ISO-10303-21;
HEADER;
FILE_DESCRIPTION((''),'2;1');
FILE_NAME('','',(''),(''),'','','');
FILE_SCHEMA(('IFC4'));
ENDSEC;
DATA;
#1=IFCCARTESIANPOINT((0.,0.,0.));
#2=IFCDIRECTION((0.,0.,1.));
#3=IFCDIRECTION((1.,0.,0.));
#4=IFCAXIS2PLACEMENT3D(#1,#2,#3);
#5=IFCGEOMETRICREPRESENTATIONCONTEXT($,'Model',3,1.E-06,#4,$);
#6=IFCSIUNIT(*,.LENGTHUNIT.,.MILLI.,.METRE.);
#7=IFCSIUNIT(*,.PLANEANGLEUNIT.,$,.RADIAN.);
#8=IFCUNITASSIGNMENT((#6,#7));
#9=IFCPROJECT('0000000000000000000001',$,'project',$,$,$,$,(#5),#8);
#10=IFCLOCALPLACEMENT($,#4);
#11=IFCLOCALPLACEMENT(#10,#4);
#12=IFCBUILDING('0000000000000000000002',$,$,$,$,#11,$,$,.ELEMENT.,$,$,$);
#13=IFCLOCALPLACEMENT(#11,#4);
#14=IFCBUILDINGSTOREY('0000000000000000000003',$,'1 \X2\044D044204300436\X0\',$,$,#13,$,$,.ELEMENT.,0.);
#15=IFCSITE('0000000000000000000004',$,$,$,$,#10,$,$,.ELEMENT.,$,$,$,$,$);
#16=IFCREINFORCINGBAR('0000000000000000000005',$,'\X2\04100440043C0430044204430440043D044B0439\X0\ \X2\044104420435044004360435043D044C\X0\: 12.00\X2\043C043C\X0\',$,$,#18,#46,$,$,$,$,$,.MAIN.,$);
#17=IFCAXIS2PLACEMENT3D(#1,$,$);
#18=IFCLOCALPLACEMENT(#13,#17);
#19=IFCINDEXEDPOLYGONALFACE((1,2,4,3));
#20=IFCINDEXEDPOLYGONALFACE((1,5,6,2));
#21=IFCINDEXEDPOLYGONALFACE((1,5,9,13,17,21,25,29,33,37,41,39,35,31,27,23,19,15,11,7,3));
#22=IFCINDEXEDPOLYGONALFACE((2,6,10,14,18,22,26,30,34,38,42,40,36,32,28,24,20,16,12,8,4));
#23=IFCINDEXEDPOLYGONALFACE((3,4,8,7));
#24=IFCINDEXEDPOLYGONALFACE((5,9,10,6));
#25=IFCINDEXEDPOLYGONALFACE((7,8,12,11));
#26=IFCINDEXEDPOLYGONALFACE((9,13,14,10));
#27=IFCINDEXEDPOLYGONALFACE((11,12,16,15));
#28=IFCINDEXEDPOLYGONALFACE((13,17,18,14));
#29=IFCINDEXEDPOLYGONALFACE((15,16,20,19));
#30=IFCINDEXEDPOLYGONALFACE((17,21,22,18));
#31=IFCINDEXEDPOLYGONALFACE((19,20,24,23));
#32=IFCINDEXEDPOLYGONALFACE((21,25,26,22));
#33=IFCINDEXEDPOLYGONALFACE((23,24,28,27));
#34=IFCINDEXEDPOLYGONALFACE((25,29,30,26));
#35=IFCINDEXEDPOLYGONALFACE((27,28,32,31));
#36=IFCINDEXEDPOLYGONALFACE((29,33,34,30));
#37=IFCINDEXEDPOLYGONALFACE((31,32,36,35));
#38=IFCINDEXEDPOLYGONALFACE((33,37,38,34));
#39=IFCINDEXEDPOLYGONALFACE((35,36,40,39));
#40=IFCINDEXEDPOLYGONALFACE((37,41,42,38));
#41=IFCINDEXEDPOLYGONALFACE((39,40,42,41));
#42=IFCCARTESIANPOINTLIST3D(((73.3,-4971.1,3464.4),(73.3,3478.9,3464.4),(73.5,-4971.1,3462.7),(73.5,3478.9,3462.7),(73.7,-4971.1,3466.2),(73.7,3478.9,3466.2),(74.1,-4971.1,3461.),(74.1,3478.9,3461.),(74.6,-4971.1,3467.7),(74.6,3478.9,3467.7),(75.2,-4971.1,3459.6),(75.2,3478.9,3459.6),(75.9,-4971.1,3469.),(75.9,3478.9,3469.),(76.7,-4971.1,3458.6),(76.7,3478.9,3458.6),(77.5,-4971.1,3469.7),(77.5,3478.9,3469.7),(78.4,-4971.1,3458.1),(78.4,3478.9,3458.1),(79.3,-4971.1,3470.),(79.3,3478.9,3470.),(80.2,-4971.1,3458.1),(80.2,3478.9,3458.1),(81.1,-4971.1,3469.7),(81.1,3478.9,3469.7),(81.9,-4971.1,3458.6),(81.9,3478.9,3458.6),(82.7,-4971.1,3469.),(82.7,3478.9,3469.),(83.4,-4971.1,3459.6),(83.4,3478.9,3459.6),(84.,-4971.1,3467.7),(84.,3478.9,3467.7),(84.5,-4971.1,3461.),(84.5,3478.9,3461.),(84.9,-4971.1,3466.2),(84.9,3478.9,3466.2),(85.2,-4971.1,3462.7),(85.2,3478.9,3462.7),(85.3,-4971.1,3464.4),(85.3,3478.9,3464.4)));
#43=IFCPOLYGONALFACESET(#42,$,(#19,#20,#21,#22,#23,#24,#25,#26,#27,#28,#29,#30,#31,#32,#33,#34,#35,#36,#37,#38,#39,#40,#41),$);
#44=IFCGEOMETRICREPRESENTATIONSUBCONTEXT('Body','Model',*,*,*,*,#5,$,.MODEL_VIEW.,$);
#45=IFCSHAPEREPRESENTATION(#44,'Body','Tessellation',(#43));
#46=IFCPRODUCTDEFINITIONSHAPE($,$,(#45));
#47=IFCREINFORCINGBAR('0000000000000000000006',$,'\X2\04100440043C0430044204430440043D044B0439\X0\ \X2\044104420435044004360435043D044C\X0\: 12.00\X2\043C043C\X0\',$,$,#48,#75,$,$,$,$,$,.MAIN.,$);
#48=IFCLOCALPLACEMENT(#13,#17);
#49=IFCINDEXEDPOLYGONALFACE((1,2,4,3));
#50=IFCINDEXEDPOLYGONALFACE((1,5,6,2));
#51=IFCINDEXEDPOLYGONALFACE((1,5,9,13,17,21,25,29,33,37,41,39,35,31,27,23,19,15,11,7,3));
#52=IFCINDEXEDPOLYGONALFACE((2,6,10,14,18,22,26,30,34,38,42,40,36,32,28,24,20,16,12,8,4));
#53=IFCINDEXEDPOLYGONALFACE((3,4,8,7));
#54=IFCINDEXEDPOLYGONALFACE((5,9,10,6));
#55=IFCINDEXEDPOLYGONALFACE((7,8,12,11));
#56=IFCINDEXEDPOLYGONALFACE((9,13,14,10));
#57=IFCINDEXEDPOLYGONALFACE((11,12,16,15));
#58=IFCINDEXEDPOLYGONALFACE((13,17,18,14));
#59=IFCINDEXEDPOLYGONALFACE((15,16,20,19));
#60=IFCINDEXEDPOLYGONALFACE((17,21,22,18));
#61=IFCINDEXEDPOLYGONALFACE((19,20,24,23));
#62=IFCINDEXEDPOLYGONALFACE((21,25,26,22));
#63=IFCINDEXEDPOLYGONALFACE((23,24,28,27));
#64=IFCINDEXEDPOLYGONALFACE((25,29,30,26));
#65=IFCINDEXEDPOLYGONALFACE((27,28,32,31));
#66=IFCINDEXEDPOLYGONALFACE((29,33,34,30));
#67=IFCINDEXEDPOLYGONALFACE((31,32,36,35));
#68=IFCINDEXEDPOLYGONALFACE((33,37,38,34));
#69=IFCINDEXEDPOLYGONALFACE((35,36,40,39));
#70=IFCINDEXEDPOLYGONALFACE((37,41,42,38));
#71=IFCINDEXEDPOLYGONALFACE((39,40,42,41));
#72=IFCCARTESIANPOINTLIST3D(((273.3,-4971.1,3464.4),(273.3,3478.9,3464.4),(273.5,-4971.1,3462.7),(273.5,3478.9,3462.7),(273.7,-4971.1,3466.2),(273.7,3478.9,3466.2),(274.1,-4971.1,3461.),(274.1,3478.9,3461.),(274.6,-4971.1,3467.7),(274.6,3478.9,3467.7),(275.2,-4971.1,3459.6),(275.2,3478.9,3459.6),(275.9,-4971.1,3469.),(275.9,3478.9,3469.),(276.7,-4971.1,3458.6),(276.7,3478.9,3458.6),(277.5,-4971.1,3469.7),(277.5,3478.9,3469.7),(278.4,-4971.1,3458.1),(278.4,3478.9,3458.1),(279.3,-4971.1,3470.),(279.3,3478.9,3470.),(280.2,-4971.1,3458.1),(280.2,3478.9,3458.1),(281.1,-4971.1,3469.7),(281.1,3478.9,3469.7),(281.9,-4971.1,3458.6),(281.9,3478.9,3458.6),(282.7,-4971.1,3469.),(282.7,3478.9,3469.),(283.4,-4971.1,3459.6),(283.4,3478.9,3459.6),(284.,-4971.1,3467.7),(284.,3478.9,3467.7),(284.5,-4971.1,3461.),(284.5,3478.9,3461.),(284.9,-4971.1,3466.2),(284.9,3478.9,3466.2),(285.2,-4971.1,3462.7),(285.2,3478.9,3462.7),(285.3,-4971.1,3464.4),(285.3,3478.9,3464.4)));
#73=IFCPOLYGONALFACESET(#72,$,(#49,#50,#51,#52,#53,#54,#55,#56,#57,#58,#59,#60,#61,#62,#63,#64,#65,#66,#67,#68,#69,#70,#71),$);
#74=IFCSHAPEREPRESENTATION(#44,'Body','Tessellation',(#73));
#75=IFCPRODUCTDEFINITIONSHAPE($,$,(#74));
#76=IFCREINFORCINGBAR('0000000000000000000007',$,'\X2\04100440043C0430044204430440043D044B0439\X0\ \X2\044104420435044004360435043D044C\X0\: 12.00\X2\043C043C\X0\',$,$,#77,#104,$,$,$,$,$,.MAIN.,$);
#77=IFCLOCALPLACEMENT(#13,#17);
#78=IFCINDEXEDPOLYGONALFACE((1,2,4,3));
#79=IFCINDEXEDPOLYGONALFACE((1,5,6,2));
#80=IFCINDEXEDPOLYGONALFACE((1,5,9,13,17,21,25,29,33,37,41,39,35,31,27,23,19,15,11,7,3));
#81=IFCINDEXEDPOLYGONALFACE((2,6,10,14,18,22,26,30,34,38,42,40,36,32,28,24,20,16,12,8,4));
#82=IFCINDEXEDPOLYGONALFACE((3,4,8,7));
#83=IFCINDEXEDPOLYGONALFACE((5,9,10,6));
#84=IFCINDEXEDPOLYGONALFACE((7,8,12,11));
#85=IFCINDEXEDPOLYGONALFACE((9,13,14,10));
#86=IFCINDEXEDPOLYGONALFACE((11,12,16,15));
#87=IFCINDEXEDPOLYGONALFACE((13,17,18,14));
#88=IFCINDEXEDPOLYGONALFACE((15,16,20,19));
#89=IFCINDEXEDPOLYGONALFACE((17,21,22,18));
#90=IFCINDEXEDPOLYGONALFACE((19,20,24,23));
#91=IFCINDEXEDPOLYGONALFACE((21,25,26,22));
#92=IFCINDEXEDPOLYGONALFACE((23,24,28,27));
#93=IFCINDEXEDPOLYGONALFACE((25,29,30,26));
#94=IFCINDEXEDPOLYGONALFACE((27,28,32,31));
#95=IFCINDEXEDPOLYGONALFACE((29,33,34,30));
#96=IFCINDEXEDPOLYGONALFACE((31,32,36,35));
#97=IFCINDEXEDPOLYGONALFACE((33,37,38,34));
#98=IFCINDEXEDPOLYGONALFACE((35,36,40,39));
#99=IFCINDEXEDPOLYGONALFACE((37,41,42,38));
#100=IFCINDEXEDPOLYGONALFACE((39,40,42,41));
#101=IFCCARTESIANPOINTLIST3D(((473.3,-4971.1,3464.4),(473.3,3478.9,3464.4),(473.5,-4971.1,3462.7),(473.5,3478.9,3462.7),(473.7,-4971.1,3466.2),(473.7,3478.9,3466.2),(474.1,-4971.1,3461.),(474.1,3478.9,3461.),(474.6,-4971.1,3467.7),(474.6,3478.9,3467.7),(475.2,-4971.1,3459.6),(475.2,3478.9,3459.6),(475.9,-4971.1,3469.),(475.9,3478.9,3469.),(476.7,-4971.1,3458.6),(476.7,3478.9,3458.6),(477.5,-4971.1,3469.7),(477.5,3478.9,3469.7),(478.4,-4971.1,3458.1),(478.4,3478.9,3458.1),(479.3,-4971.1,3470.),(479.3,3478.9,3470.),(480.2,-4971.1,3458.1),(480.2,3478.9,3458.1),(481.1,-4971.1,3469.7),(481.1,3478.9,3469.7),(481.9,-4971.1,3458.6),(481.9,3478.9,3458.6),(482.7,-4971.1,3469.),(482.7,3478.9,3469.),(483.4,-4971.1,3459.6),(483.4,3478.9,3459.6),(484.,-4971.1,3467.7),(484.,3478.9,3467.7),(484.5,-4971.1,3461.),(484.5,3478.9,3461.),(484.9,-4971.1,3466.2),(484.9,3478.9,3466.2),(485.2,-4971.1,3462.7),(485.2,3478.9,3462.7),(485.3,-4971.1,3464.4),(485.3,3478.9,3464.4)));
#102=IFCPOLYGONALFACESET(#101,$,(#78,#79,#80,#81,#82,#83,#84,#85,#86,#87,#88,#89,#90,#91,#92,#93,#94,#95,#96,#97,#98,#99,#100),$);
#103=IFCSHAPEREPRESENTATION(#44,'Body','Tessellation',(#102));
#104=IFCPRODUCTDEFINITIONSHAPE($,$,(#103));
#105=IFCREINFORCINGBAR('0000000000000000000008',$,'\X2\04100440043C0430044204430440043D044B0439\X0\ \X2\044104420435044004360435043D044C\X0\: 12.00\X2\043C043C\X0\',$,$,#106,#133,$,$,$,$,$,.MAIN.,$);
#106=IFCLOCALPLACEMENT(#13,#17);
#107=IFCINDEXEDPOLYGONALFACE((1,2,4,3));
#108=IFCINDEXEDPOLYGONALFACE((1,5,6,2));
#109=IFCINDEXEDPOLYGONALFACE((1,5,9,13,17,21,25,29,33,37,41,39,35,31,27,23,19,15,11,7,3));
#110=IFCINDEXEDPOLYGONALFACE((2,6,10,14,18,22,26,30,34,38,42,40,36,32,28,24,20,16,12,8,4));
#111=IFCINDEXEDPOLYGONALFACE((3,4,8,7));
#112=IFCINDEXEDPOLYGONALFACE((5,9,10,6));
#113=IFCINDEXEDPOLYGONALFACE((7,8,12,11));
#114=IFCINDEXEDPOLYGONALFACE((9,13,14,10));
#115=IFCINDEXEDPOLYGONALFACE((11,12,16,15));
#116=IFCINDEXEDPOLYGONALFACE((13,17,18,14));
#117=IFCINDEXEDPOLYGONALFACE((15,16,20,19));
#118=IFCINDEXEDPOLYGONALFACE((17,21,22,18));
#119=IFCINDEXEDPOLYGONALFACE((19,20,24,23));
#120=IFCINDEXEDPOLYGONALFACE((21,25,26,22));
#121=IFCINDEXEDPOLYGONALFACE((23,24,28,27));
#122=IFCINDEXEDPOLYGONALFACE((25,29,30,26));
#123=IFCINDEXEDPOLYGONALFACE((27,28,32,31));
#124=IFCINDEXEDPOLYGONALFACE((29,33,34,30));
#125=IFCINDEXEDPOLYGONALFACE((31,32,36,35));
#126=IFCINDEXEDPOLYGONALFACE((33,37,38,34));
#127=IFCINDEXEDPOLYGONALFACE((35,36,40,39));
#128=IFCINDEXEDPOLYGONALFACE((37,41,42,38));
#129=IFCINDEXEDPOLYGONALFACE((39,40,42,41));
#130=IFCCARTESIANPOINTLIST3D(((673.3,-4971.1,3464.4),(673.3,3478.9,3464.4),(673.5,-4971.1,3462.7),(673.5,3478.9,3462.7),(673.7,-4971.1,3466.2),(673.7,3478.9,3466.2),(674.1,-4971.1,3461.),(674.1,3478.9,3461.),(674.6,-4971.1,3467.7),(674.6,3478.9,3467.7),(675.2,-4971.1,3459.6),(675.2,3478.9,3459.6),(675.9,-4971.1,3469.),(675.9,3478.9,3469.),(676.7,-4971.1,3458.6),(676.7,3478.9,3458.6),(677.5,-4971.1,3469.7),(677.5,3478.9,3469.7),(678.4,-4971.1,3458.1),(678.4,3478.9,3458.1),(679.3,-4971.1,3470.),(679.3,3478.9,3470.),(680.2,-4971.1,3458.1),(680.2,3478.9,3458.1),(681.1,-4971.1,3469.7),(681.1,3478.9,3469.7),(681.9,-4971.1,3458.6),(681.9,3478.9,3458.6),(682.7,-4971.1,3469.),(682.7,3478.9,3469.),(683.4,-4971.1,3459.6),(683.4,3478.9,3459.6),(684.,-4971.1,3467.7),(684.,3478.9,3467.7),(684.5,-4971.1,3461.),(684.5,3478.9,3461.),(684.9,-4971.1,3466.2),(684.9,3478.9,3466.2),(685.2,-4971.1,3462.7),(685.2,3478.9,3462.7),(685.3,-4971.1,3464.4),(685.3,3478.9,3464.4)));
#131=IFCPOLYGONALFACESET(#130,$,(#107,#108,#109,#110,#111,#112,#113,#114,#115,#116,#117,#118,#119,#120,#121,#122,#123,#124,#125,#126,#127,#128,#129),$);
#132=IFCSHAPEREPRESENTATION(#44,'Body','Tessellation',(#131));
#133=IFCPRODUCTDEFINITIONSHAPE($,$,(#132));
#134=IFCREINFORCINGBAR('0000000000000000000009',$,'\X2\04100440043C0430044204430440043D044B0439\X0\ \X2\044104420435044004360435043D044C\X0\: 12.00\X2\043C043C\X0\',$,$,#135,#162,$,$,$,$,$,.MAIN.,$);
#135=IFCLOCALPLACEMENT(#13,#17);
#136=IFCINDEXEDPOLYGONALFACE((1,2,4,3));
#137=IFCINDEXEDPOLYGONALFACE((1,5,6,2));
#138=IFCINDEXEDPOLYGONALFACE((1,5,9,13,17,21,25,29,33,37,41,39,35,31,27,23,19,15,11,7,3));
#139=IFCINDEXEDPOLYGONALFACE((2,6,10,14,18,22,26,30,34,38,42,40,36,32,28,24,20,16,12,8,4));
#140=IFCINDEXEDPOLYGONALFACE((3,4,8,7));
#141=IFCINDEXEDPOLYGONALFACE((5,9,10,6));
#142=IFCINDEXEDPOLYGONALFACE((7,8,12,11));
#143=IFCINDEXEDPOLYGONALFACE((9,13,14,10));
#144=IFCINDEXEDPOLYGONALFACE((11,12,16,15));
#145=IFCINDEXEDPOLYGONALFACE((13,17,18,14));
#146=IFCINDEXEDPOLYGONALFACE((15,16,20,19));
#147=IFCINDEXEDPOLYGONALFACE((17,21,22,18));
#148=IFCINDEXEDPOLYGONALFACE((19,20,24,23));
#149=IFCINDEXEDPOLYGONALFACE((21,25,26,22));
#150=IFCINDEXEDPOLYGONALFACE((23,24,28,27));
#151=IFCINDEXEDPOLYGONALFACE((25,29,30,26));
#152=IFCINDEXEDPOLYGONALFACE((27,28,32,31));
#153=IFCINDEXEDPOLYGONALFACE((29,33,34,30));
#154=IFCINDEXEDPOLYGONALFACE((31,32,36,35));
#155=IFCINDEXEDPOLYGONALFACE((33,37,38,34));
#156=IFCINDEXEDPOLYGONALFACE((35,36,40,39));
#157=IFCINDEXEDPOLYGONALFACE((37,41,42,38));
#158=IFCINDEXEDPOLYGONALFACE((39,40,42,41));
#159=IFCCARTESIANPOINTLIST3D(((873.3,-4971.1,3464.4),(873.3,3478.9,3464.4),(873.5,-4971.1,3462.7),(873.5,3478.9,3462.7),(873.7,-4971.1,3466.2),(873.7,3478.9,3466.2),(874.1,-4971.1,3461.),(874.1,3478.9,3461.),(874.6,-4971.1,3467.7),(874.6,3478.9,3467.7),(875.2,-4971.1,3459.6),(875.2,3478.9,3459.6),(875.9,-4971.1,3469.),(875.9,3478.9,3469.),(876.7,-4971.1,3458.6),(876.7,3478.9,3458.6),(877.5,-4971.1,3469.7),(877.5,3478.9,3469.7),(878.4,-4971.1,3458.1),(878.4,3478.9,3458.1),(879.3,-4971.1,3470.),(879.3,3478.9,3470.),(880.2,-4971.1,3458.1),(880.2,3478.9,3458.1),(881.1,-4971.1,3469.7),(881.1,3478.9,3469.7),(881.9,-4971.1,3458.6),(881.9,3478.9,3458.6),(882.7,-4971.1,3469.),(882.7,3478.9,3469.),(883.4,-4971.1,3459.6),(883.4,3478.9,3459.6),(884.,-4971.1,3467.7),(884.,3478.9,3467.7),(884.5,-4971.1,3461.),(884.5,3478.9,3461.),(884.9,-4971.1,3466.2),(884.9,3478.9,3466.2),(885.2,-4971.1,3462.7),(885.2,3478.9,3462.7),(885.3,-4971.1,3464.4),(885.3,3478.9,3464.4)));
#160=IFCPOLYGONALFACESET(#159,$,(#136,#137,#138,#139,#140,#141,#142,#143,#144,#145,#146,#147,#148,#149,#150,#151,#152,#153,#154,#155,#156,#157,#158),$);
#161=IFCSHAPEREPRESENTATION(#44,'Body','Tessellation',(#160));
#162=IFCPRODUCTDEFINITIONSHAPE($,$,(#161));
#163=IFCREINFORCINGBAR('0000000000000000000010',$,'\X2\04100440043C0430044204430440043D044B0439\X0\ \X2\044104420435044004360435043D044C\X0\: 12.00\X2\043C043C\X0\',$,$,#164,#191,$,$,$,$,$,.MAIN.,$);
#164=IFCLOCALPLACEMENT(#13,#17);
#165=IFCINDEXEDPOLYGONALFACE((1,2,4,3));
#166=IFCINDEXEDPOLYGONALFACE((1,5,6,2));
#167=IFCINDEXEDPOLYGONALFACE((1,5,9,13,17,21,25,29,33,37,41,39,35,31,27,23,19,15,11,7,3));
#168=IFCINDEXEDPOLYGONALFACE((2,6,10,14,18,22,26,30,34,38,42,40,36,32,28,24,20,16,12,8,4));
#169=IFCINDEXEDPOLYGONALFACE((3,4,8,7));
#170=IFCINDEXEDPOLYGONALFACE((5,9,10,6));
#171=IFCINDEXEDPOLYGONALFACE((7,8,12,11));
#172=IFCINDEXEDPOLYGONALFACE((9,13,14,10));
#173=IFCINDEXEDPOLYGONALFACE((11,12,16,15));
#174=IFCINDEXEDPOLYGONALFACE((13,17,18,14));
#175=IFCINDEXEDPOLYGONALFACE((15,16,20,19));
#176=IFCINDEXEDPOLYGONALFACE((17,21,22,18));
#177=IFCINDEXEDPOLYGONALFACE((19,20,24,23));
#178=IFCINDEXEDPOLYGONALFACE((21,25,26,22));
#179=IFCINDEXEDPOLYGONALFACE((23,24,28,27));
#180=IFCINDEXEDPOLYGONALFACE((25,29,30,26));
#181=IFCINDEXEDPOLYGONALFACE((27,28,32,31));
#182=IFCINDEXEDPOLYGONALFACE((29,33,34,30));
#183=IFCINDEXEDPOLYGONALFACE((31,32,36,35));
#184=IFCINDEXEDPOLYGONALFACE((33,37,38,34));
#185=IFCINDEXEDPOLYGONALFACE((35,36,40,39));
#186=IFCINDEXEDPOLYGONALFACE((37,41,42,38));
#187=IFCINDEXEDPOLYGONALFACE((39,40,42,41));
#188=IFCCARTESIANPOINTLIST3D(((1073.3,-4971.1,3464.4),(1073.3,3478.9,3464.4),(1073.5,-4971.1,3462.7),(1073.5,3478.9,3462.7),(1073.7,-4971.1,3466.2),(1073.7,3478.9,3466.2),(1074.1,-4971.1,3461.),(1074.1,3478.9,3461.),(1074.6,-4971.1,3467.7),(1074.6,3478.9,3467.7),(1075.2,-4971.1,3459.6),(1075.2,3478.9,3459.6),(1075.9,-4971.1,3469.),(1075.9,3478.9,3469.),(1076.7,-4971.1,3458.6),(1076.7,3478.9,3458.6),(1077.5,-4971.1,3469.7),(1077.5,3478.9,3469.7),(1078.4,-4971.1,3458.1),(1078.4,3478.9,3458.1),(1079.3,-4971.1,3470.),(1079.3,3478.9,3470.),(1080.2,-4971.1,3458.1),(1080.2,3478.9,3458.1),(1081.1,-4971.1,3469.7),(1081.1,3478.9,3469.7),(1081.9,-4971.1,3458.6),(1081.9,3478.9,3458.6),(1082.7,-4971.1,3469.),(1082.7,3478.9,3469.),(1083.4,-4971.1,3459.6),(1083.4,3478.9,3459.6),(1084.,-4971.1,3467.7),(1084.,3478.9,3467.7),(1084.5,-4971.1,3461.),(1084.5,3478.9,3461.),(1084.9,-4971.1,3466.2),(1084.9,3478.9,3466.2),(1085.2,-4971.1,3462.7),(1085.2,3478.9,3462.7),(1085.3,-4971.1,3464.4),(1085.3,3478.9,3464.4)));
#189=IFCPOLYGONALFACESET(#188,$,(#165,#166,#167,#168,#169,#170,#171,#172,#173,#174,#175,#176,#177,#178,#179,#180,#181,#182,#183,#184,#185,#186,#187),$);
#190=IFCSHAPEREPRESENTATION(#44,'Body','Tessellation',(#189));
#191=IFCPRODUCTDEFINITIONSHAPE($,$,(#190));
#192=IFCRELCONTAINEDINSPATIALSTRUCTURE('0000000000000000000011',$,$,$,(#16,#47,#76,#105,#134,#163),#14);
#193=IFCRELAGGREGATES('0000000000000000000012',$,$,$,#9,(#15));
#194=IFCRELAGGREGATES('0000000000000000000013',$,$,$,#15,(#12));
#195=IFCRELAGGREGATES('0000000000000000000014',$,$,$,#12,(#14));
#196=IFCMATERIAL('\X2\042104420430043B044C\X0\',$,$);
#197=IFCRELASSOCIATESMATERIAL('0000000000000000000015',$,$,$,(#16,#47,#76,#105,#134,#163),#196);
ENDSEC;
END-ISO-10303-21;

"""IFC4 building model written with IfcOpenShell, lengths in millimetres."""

from ifc_helpers import new_model, entity, si_unit, origin_with_axes, place, context, subcontext, project, spatial, source, transform, mapped, material, element, save


model = new_model("IFC4")

# Units and contexts
model_context = context("Model", 3, precision=1e-06, world=origin_with_axes())
body_context = subcontext(model_context, "Body", "Model", "MODEL_VIEW")
ifc_project = project(units=[si_unit("LENGTHUNIT", "METRE", prefix="MILLI"), si_unit("PLANEANGLEUNIT", "RADIAN")], contexts=[model_context])

# Site, building, storey
site_placement = place(None, origin_with_axes())
site = spatial("IfcSite", under=ifc_project, at=site_placement, CompositionType="ELEMENT")
building_placement = place(site_placement, origin_with_axes())
building = spatial("IfcBuilding", under=site, at=building_placement, CompositionType="ELEMENT")
storey_placement = place(building_placement, origin_with_axes())
storey = spatial("IfcBuildingStorey", under=building, at=storey_placement, Name="1 этаж", CompositionType="ELEMENT", Elevation=0.0)

# Reinforcing bars
ifc_material = material(Name="Сталь")
shared_shape = source(origin_with_axes(), body_context, "Body", "AdvancedSweptSolid", [
    entity("IfcSweptDiskSolid", entity("IfcIndexedPolyCurve", entity("IfcCartesianPointList3D", [[0.0, 0.0, 0.0], [8450.0, 0.0, 0.0]]), [entity("IfcLineIndex", [1, 2])]), 6.0),
])
reinforcing_bar_1_placement = place(storey_placement, origin_with_axes())
element("IfcReinforcingBar", 1, at=reinforcing_bar_1_placement, inside=storey, material=ifc_material, Name="Арматурный стержень: 12.00мм", PredefinedType="MAIN", context=body_context, shape_type="MappedRepresentation", body=[
    mapped(shared_shape, transform((79.3, -4971.1, 3464.0), x_axis=(0.0, 1.0, 0.0), y_axis=(-1.0, 0.0, 0.0), z_axis=(0.0, 0.0, 1.0), scale=1.0)),
])
reinforcing_bar_2_placement = place(storey_placement, origin_with_axes())
element("IfcReinforcingBar", 2, at=reinforcing_bar_2_placement, inside=storey, material=ifc_material, Name="Арматурный стержень: 12.00мм", PredefinedType="MAIN", context=body_context, shape_type="MappedRepresentation", body=[
    mapped(shared_shape, transform((279.3, -4971.1, 3464.0), x_axis=(0.0, 1.0, 0.0), y_axis=(-1.0, 0.0, 0.0), z_axis=(0.0, 0.0, 1.0), scale=1.0)),
])
reinforcing_bar_3_placement = place(storey_placement, origin_with_axes())
element("IfcReinforcingBar", 3, at=reinforcing_bar_3_placement, inside=storey, material=ifc_material, Name="Арматурный стержень: 12.00мм", PredefinedType="MAIN", context=body_context, shape_type="MappedRepresentation", body=[
    mapped(shared_shape, transform((479.3, -4971.1, 3464.0), x_axis=(0.0, 1.0, 0.0), y_axis=(-1.0, 0.0, 0.0), z_axis=(0.0, 0.0, 1.0), scale=1.0)),
])
reinforcing_bar_4_placement = place(storey_placement, origin_with_axes())
element("IfcReinforcingBar", 4, at=reinforcing_bar_4_placement, inside=storey, material=ifc_material, Name="Арматурный стержень: 12.00мм", PredefinedType="MAIN", context=body_context, shape_type="MappedRepresentation", body=[
    mapped(shared_shape, transform((679.3, -4971.1, 3464.0), x_axis=(0.0, 1.0, 0.0), y_axis=(-1.0, 0.0, 0.0), z_axis=(0.0, 0.0, 1.0), scale=1.0)),
])
reinforcing_bar_5_placement = place(storey_placement, origin_with_axes())
element("IfcReinforcingBar", 5, at=reinforcing_bar_5_placement, inside=storey, material=ifc_material, Name="Арматурный стержень: 12.00мм", PredefinedType="MAIN", context=body_context, shape_type="MappedRepresentation", body=[
    mapped(shared_shape, transform((879.3, -4971.1, 3464.0), x_axis=(0.0, 1.0, 0.0), y_axis=(-1.0, 0.0, 0.0), z_axis=(0.0, 0.0, 1.0), scale=1.0)),
])
reinforcing_bar_6_placement = place(storey_placement, origin_with_axes())
element("IfcReinforcingBar", 6, at=reinforcing_bar_6_placement, inside=storey, material=ifc_material, Name="Арматурный стержень: 12.00мм", PredefinedType="MAIN", context=body_context, shape_type="MappedRepresentation", body=[
    mapped(shared_shape, transform((1079.3, -4971.1, 3464.0), x_axis=(0.0, 1.0, 0.0), y_axis=(-1.0, 0.0, 0.0), z_axis=(0.0, 0.0, 1.0), scale=1.0)),
])

save(model, "model.ifc")
